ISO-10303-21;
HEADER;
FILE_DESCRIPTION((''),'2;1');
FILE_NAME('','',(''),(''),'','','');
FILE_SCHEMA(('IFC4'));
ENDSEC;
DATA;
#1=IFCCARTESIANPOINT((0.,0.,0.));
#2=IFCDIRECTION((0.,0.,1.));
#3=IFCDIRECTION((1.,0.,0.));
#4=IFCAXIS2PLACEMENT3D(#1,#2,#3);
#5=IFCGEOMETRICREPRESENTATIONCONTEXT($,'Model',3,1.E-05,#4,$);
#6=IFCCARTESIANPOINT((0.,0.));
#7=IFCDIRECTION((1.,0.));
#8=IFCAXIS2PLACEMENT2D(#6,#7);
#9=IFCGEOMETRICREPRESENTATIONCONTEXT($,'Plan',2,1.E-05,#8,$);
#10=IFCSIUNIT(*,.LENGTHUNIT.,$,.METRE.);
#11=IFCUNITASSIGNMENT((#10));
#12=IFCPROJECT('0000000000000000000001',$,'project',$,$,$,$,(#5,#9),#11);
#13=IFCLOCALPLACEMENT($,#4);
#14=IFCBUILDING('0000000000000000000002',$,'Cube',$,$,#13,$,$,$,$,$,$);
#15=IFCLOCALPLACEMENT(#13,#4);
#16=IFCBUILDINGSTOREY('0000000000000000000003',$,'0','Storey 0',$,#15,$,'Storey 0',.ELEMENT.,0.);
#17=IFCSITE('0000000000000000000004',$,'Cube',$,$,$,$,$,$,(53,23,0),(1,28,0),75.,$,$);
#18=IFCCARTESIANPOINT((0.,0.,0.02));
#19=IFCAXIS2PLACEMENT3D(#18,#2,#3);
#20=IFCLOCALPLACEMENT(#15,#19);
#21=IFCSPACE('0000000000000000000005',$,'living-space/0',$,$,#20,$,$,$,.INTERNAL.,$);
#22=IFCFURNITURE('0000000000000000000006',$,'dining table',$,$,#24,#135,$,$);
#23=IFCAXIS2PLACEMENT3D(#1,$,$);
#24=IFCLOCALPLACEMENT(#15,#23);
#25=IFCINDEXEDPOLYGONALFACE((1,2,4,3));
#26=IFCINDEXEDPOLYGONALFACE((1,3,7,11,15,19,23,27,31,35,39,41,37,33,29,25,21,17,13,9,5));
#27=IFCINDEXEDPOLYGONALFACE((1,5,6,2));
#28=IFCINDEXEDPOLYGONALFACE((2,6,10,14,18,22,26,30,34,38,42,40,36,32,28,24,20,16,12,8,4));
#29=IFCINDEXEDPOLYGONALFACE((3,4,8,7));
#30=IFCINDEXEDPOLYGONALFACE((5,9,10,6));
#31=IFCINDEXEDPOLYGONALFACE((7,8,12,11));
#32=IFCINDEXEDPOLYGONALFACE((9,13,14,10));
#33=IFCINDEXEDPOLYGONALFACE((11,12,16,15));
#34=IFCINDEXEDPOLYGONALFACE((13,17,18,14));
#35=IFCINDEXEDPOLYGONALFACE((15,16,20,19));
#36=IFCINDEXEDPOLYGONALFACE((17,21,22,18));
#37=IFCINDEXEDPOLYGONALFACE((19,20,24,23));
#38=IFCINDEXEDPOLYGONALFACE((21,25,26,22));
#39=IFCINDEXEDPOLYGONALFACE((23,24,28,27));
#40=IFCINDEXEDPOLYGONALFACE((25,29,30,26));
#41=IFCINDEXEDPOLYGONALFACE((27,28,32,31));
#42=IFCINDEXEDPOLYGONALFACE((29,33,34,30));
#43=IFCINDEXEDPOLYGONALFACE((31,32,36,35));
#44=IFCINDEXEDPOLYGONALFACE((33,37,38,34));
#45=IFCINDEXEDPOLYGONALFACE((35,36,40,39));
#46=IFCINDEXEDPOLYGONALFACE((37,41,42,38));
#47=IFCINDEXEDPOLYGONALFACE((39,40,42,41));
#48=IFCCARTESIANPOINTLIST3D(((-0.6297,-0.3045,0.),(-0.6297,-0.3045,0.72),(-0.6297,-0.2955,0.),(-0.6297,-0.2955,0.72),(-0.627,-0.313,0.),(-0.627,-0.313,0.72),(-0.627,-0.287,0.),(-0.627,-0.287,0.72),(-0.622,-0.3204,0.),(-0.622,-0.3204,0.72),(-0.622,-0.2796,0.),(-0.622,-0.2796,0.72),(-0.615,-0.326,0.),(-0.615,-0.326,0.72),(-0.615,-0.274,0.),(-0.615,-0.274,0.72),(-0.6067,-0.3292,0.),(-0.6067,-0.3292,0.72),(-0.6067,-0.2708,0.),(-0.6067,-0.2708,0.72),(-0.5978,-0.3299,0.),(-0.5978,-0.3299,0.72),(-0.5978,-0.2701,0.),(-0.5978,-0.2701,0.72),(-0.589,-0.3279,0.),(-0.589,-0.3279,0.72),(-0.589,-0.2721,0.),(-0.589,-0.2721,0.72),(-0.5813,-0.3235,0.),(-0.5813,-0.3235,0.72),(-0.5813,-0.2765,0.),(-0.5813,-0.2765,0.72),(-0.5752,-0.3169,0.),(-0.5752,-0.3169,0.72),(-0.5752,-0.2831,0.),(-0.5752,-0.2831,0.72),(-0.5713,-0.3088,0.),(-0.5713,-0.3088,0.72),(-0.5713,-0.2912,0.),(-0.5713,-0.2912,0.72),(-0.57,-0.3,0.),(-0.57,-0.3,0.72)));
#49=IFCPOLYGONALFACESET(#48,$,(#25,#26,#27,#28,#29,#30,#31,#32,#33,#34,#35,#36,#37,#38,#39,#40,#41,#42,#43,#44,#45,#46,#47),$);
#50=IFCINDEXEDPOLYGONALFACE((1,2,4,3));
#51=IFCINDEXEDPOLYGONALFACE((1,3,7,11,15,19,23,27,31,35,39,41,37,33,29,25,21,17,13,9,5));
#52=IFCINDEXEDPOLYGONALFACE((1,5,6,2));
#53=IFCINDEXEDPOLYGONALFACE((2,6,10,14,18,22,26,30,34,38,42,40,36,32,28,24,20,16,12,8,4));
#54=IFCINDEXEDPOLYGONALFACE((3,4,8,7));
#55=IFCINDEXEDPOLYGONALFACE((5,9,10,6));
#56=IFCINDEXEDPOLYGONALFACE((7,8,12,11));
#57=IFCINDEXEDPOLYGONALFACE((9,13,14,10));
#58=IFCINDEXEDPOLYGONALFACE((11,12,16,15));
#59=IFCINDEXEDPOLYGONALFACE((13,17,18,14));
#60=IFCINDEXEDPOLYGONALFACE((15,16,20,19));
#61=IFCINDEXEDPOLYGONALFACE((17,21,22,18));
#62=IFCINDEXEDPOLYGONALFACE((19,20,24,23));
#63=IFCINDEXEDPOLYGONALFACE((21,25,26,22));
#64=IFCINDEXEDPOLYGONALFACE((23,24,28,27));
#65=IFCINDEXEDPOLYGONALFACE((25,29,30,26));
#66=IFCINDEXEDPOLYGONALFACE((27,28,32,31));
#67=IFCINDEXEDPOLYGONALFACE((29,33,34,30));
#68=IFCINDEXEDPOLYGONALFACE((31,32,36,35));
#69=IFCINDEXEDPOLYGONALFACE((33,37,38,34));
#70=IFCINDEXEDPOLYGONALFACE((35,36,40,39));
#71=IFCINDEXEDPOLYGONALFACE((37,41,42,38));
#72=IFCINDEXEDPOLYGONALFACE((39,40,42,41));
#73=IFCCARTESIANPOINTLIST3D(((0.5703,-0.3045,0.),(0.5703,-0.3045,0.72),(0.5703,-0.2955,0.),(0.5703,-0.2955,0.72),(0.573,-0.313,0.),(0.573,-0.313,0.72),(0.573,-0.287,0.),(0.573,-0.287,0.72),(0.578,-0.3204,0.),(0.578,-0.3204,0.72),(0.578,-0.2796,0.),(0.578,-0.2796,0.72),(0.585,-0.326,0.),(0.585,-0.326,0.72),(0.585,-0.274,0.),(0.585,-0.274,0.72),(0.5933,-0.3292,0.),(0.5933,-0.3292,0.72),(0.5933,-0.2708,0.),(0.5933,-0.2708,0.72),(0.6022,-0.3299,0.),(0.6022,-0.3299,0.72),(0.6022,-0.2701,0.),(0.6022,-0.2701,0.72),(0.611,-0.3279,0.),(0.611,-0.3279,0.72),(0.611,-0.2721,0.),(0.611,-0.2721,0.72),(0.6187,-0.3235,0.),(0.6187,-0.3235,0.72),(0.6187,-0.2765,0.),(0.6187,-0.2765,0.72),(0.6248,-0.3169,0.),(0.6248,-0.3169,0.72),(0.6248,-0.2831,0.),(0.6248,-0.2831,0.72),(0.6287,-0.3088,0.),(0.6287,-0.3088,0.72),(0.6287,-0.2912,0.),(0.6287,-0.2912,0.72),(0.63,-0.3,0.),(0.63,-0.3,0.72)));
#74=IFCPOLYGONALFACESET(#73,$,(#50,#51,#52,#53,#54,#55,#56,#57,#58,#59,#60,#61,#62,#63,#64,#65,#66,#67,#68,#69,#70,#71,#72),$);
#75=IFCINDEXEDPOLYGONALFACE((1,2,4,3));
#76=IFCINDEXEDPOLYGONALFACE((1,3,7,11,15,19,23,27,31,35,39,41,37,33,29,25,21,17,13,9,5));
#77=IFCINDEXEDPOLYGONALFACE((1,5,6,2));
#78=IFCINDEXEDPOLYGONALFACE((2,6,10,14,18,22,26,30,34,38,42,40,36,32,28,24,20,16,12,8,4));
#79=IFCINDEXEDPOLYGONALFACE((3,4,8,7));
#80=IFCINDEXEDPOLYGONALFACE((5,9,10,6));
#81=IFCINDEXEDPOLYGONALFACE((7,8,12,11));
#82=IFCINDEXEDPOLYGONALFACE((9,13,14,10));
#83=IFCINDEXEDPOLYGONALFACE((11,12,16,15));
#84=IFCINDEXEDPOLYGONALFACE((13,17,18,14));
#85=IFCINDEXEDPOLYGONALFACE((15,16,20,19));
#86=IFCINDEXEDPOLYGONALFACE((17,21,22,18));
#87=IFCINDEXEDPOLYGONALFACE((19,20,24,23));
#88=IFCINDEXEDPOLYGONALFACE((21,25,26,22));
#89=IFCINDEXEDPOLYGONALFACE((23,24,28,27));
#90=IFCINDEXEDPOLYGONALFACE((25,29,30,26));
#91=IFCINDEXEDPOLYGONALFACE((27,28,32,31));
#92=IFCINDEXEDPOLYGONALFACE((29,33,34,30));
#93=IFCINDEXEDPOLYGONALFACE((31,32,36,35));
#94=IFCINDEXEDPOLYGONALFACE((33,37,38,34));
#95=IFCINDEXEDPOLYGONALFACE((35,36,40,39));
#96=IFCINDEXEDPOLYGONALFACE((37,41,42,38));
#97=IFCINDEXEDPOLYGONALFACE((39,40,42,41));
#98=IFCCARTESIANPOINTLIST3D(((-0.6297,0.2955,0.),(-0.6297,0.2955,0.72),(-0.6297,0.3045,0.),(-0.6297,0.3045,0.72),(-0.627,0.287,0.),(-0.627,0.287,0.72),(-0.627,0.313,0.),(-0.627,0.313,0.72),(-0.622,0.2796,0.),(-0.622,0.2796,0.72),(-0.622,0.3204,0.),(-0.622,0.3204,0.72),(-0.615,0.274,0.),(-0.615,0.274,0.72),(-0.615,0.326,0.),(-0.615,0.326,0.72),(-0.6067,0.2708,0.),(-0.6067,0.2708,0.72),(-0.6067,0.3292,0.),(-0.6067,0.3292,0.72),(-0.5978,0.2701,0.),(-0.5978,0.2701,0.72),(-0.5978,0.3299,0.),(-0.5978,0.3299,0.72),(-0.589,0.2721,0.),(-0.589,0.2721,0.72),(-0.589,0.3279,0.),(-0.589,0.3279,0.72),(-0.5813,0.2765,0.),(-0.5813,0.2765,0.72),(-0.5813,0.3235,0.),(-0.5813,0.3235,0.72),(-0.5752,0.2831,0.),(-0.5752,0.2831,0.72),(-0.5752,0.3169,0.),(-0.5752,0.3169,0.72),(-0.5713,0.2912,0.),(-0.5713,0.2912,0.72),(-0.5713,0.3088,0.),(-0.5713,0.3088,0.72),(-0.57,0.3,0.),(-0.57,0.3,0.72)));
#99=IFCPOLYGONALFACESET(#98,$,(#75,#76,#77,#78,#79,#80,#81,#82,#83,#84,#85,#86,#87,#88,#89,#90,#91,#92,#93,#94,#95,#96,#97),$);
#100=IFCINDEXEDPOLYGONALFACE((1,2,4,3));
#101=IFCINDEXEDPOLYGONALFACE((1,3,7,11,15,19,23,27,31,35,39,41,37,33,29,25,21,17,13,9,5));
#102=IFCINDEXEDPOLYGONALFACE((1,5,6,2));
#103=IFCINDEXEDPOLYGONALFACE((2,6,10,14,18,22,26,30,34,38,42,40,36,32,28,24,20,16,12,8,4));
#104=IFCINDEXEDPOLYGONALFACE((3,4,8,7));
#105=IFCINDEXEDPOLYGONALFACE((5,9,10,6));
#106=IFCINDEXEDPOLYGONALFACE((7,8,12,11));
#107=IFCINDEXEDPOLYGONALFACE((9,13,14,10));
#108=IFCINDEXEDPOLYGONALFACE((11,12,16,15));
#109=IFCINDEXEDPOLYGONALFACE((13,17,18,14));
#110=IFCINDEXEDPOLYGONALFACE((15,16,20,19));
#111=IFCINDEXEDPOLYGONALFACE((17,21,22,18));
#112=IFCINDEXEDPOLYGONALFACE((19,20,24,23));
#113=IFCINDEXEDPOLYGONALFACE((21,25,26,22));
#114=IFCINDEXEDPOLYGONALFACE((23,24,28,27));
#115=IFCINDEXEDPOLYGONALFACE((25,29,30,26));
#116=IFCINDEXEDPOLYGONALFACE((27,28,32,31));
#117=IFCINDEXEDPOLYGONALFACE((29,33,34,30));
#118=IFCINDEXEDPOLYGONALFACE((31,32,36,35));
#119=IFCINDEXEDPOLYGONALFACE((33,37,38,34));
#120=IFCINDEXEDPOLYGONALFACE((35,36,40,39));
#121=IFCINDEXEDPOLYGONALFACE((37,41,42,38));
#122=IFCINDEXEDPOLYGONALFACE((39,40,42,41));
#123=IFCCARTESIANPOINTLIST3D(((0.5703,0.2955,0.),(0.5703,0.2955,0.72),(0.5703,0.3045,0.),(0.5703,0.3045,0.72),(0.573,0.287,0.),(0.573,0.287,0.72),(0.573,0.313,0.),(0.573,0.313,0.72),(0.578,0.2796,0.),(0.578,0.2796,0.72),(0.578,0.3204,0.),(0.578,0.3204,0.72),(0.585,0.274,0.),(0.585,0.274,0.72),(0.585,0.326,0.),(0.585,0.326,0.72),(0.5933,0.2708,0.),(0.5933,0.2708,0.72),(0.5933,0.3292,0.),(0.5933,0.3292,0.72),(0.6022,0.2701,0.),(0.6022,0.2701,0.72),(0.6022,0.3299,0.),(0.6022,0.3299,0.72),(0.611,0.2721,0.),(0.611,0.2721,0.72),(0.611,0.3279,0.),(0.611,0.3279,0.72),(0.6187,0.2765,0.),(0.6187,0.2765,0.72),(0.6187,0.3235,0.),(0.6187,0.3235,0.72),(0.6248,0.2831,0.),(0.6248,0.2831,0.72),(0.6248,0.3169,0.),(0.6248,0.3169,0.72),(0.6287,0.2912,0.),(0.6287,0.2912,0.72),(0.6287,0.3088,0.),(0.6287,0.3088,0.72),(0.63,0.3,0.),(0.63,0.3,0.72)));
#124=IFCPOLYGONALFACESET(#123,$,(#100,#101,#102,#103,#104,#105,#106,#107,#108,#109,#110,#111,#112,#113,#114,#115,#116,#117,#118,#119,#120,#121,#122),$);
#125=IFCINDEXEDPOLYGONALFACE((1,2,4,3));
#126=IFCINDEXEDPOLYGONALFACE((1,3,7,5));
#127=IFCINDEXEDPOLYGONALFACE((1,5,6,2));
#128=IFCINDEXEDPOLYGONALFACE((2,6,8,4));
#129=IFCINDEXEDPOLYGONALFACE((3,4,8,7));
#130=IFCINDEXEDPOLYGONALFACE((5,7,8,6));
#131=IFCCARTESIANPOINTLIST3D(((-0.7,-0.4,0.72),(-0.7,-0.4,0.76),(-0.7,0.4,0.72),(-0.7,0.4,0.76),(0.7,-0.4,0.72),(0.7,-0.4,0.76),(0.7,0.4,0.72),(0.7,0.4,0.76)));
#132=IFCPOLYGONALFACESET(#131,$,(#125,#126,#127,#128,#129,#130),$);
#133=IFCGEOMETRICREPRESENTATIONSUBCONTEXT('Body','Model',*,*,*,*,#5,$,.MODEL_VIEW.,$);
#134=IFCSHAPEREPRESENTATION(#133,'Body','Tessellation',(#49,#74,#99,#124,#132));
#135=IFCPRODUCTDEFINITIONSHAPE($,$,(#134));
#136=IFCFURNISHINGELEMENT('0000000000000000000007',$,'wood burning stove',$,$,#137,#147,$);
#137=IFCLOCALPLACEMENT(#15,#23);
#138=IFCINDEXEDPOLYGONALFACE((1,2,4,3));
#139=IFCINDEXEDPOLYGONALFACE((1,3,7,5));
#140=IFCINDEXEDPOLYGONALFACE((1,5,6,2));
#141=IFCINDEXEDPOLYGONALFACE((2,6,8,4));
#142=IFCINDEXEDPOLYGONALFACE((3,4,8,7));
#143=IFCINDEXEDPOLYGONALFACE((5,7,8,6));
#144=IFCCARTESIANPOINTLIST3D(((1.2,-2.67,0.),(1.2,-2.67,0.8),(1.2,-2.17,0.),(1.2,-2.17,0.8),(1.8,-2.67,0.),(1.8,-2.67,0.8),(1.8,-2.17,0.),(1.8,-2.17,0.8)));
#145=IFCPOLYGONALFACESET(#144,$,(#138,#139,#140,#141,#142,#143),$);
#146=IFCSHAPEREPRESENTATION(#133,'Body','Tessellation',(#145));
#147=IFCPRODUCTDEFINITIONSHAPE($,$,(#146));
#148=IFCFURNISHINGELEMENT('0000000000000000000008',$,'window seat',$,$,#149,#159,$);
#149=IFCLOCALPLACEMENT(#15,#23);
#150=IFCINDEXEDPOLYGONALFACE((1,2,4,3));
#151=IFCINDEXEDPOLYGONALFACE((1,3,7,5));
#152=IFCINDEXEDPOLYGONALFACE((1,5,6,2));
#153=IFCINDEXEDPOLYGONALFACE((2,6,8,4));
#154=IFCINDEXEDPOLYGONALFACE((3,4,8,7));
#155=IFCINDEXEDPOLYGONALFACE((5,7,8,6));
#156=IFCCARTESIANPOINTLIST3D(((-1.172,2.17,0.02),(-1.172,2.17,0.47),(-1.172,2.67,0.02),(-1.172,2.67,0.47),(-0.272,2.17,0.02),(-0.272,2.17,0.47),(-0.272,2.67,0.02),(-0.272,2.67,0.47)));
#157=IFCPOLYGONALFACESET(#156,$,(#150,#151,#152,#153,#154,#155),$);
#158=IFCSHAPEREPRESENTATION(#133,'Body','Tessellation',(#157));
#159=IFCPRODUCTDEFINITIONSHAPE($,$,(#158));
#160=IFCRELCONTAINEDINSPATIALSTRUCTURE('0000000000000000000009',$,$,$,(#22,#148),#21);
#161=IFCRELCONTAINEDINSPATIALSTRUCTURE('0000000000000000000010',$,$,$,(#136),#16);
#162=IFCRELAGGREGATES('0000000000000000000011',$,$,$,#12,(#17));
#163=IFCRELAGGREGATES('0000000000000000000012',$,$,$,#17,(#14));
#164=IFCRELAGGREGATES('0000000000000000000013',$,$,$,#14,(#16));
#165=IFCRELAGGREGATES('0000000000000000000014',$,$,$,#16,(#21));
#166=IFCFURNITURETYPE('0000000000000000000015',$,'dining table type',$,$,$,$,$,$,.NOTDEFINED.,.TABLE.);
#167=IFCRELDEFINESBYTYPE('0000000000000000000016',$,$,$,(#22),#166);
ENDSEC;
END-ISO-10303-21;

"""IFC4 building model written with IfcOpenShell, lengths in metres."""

from ifc_helpers import new_model, entity, si_unit, frame, origin_with_axes, origin_2d_with_axis, place, context, subcontext, project, spatial, line, indexed_curve, outline, extrude, source, transform, mapped, type_object, type_shapes, element, save


model = new_model("IFC4")

# Units and contexts
model_context = context("Model", 3, precision=1e-05, world=origin_with_axes())
plan_context = context("Plan", 2, precision=1e-05, world=origin_2d_with_axis())
body_context_1 = subcontext(model_context, "Body", "Model", "MODEL_VIEW")
ifc_project = project(units=[si_unit("LENGTHUNIT", "METRE")], contexts=[model_context, plan_context])

# Site, building, storey
site = spatial("IfcSite", under=ifc_project, Name="Cube", RefLatitude=(53, 23, 0), RefLongitude=(1, 28, 0), RefElevation=75.0)
building_placement = place(None, origin_with_axes())
building = spatial("IfcBuilding", under=site, at=building_placement, Name="Cube")
storey_placement = place(building_placement, origin_with_axes())
storey = spatial("IfcBuildingStorey", under=building, at=storey_placement, Name="0", Description="Storey 0", LongName="Storey 0", CompositionType="ELEMENT", Elevation=0.0)

# Shared definitions
space_placement = place(storey_placement, frame((0.0, 0.0, 0.02), z_axis=(0.0, 0.0, 1.0), x_axis=(1.0, 0.0, 0.0)))
space = spatial("IfcSpace", under=storey, at=space_placement, Name="living-space/0", PredefinedType="INTERNAL")

# Furniture
furniture_type_1 = type_object("IfcFurnitureType", Name="dining table type", AssemblyPlace="NOTDEFINED", PredefinedType="TABLE")
shared_circle = entity("IfcCircle", entity("IfcAxis2Placement2D", entity("IfcCartesianPoint", [0.0, 0.0])), 0.03)
shared_shape_1 = source(origin_with_axes(), body_context_1, "Body", "SweptSolid", [
    entity("IfcExtrudedAreaSolid", entity("IfcArbitraryClosedProfileDef", "AREA", None, shared_circle), entity("IfcAxis2Placement3D", entity("IfcCartesianPoint", [-0.6, -0.3, 0.0]), entity("IfcDirection", [0.0, 0.0, 1.0]), entity("IfcDirection", [1.0, 0.0, 0.0])), entity("IfcDirection", [0.0, 0.0, 1.0]), 0.72),
    entity("IfcExtrudedAreaSolid", entity("IfcArbitraryClosedProfileDef", "AREA", None, shared_circle), entity("IfcAxis2Placement3D", entity("IfcCartesianPoint", [0.6, -0.3, 0.0]), entity("IfcDirection", [0.0, 0.0, 1.0]), entity("IfcDirection", [1.0, 0.0, 0.0])), entity("IfcDirection", [0.0, 0.0, 1.0]), 0.72),
    entity("IfcExtrudedAreaSolid", entity("IfcArbitraryClosedProfileDef", "AREA", None, shared_circle), entity("IfcAxis2Placement3D", entity("IfcCartesianPoint", [-0.6, 0.3, 0.0]), entity("IfcDirection", [0.0, 0.0, 1.0]), entity("IfcDirection", [1.0, 0.0, 0.0])), entity("IfcDirection", [0.0, 0.0, 1.0]), 0.72),
    entity("IfcExtrudedAreaSolid", entity("IfcArbitraryClosedProfileDef", "AREA", None, shared_circle), entity("IfcAxis2Placement3D", entity("IfcCartesianPoint", [0.6, 0.3, 0.0]), entity("IfcDirection", [0.0, 0.0, 1.0]), entity("IfcDirection", [1.0, 0.0, 0.0])), entity("IfcDirection", [0.0, 0.0, 1.0]), 0.72),
    extrude(outline(indexed_curve([(-0.7, -0.4), (0.7, -0.4), (0.7, 0.4), (-0.7, 0.4)], segments=[line(1, 2, 3, 4, 1)])), frame((0.0, 0.0, 0.72), z_axis=(0.0, 0.0, 1.0), x_axis=(1.0, 0.0, 0.0)), (0.0, 0.0, 1.0), 0.04),
])
type_shapes(furniture_type_1, [shared_shape_1])
furniture_placement = place(space_placement, frame((0.0, 0.0, -0.02), z_axis=(0.0, 0.0, 1.0), x_axis=(1.0, 0.0, 0.0)))
element("IfcFurniture", 1, at=furniture_placement, inside=space, type_object=furniture_type_1, Name="dining table", context=body_context_1, shape_type="MappedRepresentation", body=[
    mapped(shared_shape_1, transform((0.0, 0.0, 0.0), x_axis=(1.0, 0.0, 0.0), y_axis=(0.0, 1.0, 0.0), z_axis=(0.0, 0.0, 1.0), scale=1.0)),
])

# Furnishing elements
furnishing_1_placement = place(storey_placement, frame((1.2, -2.67, 0.0), z_axis=(0.0, 0.0, 1.0), x_axis=(1.0, 0.0, 0.0)))
element("IfcFurnishingElement", 2, at=furnishing_1_placement, inside=storey, Name="wood burning stove", context=body_context_1, shape_type="SweptSolid", body=[
    extrude(outline(indexed_curve([(0.0, 0.0), (0.6, 0.0), (0.6, 0.5), (0.0, 0.5)])), None, (0.0, 0.0, 1.0), 0.8),
])
furnishing_2_placement = place(space_placement, frame((-1.172, 2.17, 0.0), z_axis=(0.0, 0.0, 1.0), x_axis=(1.0, 0.0, 0.0)))
element("IfcFurnishingElement", 3, at=furnishing_2_placement, inside=space, Name="window seat", context=body_context_1, shape_type="SweptSolid", body=[
    extrude(outline(indexed_curve([(0.0, 0.0), (0.9, 0.0), (0.9, 0.5), (0.0, 0.5)])), None, (0.0, 0.0, 1.0), 0.45),
])

save(model, "model.ifc")
